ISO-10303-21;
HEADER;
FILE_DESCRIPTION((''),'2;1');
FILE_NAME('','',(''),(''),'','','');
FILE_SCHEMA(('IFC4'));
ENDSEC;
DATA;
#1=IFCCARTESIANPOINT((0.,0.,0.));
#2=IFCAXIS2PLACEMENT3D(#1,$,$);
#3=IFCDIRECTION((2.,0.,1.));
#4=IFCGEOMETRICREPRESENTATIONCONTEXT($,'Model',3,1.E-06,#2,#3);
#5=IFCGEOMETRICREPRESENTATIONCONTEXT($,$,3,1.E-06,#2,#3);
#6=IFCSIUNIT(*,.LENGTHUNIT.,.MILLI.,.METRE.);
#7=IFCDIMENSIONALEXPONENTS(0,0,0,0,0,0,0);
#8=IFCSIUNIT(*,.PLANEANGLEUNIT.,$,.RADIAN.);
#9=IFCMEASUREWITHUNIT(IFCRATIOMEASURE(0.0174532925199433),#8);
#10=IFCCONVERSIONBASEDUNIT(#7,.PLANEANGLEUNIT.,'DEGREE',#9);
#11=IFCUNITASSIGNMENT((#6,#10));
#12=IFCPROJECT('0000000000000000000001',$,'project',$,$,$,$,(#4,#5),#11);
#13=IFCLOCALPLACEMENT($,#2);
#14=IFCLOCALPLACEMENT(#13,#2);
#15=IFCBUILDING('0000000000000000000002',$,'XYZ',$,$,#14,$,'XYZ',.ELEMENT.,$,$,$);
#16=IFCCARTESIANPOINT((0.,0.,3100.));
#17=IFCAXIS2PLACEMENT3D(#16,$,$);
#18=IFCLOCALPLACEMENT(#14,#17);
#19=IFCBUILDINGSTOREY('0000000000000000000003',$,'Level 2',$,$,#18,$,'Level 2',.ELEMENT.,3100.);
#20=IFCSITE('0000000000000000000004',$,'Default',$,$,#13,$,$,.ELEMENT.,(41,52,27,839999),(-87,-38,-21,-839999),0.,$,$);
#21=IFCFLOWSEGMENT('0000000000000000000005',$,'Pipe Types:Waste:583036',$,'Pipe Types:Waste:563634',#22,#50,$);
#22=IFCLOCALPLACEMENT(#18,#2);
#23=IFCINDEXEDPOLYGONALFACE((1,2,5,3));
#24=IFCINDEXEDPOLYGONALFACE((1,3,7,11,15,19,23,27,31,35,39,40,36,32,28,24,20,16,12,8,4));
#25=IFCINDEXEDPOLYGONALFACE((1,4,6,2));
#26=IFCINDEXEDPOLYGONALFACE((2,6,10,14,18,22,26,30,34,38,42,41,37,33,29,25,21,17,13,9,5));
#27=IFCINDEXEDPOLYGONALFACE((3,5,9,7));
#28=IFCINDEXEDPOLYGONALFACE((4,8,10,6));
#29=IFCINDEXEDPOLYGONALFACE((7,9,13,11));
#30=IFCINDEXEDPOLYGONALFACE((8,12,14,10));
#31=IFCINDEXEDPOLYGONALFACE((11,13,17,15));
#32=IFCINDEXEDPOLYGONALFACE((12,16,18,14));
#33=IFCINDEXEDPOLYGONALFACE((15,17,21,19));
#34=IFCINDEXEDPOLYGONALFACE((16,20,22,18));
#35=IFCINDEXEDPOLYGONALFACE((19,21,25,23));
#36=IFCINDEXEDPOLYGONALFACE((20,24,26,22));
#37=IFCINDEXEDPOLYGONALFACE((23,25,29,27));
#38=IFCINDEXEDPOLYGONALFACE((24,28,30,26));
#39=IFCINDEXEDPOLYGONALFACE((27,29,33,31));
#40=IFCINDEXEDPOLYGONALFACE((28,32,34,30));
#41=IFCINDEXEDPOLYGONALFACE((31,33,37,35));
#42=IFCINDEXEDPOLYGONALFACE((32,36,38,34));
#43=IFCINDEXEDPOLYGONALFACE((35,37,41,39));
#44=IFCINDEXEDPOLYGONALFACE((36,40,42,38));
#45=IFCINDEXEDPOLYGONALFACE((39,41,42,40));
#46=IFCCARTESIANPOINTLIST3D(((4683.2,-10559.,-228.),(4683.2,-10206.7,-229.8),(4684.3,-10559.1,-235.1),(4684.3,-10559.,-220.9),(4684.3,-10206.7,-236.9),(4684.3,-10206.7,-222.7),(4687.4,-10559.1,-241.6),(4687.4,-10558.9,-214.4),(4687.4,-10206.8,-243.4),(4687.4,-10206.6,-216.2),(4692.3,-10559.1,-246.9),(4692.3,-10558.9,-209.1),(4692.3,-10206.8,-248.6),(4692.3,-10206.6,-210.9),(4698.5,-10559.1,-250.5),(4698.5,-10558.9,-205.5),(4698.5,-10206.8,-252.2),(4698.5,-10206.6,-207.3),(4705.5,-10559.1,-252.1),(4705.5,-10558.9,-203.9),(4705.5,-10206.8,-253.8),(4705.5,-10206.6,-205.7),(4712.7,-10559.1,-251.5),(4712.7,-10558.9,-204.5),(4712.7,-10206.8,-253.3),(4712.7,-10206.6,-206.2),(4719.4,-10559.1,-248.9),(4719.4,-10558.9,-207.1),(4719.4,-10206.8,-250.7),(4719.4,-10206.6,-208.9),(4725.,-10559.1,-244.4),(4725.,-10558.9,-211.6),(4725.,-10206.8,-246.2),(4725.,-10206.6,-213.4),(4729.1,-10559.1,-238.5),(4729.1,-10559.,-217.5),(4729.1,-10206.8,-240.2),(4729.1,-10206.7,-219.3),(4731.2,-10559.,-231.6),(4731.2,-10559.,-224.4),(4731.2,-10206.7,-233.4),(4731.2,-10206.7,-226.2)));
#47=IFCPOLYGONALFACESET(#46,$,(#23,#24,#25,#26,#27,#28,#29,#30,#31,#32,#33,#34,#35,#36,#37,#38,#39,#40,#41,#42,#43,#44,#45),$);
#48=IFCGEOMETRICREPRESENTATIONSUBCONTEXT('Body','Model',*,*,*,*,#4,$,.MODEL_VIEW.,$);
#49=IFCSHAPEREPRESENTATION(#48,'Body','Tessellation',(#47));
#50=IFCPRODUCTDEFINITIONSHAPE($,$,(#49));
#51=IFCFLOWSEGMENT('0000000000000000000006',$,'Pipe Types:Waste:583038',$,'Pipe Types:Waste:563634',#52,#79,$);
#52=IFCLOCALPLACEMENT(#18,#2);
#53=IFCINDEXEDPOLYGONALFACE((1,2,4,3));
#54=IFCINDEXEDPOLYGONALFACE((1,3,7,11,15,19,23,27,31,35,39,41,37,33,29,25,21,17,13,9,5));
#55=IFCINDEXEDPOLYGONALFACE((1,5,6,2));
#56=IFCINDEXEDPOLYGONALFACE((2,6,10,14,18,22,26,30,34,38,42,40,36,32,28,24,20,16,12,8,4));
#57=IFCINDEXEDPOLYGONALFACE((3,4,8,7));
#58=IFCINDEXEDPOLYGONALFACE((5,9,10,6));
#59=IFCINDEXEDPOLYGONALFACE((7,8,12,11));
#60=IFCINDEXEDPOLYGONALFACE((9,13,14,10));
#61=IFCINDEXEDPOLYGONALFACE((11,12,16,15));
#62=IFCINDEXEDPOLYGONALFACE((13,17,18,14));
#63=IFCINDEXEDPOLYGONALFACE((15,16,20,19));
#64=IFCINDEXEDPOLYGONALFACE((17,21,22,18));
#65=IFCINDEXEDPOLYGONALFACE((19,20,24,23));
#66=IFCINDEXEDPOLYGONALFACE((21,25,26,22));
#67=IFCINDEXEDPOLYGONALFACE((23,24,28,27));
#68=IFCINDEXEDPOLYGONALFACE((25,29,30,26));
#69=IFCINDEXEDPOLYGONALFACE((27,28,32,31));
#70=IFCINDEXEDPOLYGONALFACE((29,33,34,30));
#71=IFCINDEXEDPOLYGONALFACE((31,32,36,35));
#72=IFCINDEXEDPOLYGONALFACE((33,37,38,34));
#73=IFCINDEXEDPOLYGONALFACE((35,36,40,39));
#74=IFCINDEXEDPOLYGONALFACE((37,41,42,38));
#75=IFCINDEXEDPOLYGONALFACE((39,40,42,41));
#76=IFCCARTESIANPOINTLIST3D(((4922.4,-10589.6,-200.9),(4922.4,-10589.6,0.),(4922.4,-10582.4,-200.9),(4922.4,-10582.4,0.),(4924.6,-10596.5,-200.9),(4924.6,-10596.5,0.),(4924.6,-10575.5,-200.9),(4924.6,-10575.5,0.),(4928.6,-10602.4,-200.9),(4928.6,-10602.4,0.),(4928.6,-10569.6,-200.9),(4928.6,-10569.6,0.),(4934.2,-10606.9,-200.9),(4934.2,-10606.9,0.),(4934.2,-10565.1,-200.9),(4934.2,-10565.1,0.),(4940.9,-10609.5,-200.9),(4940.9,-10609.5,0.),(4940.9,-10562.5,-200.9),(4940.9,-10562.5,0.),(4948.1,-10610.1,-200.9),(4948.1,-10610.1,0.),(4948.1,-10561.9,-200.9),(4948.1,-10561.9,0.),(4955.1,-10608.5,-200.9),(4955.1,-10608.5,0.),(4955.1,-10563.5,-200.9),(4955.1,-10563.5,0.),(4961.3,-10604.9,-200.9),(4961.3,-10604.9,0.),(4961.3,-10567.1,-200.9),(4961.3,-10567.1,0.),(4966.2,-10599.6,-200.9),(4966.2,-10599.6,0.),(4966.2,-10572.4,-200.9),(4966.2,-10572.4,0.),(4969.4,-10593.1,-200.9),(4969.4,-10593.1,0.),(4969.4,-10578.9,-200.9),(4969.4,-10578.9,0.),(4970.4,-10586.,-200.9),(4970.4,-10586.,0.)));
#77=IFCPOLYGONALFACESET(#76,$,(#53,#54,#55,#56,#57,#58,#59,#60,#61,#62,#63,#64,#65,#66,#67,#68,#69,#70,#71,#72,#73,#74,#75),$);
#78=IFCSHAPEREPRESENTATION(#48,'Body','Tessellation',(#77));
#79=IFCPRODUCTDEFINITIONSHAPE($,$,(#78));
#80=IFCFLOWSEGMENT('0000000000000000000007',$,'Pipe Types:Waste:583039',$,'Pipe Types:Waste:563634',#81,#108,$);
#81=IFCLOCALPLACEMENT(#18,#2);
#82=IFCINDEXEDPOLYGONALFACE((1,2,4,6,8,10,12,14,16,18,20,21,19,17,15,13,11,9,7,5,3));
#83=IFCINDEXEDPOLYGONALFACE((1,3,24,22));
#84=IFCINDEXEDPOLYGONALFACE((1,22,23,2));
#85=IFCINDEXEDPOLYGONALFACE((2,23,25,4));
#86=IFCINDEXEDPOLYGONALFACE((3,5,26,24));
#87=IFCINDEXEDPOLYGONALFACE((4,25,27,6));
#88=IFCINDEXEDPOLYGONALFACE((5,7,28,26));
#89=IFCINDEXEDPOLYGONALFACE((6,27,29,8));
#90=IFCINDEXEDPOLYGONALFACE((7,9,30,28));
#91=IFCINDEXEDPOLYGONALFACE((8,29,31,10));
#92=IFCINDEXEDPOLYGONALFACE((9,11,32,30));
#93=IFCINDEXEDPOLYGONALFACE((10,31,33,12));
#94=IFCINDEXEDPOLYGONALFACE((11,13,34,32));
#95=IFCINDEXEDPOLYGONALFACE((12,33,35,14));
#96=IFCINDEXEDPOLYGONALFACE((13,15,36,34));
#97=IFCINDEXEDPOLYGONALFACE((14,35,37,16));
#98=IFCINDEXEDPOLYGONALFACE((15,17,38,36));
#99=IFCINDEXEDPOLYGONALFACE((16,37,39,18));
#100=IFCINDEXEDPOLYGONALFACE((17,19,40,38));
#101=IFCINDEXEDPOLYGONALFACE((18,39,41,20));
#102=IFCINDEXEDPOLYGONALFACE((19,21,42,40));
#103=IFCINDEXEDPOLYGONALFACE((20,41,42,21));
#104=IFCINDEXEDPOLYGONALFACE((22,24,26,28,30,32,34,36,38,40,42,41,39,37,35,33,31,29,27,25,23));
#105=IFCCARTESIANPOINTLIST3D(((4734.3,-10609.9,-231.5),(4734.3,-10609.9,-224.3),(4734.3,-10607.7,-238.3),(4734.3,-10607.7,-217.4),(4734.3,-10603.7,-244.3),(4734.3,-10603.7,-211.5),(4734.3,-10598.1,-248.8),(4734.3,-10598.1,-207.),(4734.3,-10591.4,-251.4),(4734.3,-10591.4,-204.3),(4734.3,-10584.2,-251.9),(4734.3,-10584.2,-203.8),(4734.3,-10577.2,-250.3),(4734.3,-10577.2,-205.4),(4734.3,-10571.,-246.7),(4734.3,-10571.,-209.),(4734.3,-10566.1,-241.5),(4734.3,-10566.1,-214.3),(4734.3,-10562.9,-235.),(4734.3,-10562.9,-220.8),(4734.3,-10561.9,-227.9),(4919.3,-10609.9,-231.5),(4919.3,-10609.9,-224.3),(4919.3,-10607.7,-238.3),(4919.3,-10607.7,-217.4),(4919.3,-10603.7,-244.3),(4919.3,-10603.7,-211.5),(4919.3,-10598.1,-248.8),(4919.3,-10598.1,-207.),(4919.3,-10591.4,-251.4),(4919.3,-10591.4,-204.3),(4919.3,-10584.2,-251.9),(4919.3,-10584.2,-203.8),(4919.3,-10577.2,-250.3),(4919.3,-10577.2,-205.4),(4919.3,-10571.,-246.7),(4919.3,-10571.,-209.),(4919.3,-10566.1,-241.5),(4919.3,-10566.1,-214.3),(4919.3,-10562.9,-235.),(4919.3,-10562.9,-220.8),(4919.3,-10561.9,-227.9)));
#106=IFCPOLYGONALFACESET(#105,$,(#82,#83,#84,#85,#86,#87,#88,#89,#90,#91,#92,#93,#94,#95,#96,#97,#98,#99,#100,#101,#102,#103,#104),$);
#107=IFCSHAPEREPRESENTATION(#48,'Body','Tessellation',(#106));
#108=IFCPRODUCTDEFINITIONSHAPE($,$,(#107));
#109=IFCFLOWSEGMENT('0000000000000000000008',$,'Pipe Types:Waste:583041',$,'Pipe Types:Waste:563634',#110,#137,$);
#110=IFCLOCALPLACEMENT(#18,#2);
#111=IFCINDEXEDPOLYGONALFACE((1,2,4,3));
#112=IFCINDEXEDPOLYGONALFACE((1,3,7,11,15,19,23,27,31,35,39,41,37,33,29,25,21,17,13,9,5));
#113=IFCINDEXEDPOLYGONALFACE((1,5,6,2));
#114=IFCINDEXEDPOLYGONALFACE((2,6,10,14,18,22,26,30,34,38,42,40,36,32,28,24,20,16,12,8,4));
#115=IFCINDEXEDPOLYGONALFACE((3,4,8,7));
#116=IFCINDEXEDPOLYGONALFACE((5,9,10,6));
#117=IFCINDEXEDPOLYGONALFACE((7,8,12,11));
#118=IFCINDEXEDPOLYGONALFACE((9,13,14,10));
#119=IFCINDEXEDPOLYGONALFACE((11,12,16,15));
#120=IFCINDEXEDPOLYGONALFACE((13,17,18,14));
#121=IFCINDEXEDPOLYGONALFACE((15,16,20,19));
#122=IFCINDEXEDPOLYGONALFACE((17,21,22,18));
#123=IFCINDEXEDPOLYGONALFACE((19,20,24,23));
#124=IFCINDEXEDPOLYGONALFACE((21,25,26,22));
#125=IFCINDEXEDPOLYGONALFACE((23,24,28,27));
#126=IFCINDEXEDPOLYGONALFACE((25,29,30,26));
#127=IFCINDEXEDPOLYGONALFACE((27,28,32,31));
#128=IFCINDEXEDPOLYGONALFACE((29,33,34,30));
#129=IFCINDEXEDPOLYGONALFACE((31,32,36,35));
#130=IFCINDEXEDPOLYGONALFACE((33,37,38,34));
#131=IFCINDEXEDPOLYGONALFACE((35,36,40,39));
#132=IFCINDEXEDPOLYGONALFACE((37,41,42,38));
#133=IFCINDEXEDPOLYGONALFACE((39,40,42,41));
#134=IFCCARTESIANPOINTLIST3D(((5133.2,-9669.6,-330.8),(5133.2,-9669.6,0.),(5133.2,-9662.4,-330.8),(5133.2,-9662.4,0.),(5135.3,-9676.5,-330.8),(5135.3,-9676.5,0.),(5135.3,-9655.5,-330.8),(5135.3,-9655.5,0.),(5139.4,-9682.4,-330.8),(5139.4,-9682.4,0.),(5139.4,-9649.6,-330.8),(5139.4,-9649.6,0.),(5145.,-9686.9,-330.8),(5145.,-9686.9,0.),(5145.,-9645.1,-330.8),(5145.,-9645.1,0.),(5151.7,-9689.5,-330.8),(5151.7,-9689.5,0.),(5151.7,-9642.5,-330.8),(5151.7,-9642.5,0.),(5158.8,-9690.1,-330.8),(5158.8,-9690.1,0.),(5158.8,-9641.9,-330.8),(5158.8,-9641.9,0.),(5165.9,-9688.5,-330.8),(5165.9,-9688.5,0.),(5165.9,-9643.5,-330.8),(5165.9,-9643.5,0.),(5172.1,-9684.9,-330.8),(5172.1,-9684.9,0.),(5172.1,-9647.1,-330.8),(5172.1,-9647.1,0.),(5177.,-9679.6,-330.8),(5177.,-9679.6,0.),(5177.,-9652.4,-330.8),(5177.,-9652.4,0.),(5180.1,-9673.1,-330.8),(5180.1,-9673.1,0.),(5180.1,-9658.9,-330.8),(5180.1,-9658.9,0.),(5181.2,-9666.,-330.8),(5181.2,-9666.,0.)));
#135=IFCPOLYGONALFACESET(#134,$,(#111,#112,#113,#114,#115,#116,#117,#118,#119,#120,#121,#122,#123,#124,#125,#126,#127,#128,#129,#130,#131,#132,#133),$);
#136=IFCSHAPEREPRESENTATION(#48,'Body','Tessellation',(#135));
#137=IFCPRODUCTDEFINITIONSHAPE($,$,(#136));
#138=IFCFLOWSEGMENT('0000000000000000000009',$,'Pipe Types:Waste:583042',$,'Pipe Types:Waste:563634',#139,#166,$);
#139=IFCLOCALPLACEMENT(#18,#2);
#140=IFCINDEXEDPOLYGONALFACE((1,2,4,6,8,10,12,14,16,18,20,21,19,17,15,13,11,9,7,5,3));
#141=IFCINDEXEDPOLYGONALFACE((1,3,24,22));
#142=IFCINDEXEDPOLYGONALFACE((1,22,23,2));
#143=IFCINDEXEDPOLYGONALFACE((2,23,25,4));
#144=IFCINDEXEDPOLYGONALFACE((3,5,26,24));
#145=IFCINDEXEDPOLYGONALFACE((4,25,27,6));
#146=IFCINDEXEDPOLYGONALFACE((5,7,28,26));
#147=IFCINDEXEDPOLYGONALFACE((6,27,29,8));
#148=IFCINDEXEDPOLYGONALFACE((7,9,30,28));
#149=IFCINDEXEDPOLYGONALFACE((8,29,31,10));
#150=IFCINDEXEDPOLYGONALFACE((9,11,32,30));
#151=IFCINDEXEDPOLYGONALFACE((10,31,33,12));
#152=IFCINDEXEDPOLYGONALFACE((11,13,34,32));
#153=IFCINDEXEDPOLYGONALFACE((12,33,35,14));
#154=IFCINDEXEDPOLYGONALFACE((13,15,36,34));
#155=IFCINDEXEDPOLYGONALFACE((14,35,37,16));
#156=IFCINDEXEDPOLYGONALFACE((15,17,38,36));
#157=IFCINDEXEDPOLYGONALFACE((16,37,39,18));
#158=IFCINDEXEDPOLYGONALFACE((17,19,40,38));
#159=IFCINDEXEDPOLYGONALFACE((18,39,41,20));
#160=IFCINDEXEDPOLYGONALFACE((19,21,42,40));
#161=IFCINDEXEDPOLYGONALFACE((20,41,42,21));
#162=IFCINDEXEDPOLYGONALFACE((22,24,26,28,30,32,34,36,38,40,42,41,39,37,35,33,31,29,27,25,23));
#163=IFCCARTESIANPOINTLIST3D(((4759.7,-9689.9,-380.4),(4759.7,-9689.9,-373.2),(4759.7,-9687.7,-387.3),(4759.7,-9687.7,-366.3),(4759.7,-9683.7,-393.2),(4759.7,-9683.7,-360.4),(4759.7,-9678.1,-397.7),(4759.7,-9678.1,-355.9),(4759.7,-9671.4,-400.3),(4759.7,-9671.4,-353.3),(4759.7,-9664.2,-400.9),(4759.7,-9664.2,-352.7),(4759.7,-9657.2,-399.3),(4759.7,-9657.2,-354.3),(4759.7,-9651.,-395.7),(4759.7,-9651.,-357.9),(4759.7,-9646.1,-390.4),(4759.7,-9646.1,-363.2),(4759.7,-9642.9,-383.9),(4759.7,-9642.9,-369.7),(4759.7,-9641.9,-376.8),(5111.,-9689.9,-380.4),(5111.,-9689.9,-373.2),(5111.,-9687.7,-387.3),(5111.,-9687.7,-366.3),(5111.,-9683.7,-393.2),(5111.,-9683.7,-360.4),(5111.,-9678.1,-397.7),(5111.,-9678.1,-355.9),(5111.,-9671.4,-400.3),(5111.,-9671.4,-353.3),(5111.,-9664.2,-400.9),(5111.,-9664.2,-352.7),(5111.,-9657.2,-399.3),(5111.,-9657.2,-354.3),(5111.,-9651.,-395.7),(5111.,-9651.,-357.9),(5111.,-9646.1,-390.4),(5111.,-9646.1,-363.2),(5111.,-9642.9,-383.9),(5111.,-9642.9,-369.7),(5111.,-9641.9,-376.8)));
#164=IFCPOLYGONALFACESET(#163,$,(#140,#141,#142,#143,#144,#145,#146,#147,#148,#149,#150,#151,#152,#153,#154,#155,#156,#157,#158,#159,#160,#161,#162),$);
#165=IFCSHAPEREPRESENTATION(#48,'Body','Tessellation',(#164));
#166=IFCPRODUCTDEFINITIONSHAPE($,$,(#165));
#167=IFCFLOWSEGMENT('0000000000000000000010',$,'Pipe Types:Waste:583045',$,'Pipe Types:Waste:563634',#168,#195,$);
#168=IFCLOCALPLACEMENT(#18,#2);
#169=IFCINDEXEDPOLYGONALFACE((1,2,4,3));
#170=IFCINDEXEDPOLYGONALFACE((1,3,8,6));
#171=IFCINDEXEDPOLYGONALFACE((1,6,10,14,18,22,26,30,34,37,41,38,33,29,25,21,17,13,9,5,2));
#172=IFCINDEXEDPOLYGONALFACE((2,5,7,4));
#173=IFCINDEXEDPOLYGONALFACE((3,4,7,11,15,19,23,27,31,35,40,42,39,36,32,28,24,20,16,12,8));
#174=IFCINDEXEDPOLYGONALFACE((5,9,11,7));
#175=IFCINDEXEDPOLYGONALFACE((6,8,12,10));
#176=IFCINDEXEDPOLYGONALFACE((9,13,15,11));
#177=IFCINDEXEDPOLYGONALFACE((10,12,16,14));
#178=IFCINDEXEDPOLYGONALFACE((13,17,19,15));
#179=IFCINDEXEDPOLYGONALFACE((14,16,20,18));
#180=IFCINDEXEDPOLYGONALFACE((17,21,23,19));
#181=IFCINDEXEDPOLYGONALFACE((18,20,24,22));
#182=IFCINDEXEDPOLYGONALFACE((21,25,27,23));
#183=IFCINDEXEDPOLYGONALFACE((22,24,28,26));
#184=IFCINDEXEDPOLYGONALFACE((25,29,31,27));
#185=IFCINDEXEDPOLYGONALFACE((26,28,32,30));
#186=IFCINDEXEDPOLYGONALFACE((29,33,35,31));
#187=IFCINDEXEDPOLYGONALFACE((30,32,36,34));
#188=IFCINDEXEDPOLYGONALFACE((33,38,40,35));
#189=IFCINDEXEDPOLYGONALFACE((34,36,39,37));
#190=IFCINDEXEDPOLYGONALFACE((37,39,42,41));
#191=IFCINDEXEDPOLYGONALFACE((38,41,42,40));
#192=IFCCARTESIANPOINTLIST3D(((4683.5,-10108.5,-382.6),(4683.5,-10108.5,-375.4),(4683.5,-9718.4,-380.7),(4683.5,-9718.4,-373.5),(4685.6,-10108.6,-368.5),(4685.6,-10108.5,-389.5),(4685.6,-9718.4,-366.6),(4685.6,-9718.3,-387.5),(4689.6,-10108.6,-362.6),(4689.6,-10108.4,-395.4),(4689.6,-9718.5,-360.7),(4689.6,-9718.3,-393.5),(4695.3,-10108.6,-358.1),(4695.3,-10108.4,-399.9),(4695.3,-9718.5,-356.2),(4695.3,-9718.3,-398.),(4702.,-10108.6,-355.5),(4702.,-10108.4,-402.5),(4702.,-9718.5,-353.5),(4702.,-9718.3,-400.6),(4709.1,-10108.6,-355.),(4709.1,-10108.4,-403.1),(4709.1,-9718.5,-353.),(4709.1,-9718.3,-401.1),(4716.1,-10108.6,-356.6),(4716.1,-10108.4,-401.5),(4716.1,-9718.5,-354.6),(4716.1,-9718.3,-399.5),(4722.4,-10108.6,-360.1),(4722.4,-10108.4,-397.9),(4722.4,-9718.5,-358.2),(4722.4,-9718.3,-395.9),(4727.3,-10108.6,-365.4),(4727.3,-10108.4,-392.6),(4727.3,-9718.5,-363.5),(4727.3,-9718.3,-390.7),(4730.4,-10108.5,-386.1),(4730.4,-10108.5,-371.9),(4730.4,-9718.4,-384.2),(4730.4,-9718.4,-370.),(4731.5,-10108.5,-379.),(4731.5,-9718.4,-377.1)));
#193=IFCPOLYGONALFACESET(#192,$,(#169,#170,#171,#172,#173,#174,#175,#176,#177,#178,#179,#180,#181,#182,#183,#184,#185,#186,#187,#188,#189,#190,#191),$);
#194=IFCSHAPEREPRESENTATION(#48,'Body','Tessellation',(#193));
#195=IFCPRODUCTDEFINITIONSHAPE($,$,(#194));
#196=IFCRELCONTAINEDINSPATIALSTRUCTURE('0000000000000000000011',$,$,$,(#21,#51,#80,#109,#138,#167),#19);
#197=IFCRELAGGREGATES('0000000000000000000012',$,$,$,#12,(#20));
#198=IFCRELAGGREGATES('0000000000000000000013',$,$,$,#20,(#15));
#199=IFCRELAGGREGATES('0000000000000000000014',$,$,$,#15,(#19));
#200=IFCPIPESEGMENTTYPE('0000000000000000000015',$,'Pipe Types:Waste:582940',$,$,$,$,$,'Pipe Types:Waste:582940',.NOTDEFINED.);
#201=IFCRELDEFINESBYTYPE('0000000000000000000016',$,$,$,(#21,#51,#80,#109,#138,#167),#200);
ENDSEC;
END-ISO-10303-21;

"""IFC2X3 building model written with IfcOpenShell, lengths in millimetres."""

from ifc_helpers import new_model, entity, si_unit, converted_unit, direction, frame, frame_2d, origin, origin_2d_with_axis, place, context, subcontext, project, spatial, circle, extrude, type_object, element, save


model = new_model("IFC2X3")

# Units and contexts
model_context = context("Model", 3, precision=1e-06, world=origin(), true_north=direction((2.0, 0.0, 1.0)))
context_of_model = context(None, 3, precision=1e-06, world=origin(), true_north=direction((2.0, 0.0, 1.0)))
body_context = subcontext(model_context, "Body", "Model", "MODEL_VIEW")
ifc_project = project(units=[si_unit("LENGTHUNIT", "METRE", prefix="MILLI"), converted_unit("PLANEANGLEUNIT", "DEGREE", entity("IfcRatioMeasure", 0.0174532925199433), si_unit("PLANEANGLEUNIT", "RADIAN"), dimensions=[0, 0, 0, 0, 0, 0, 0])], contexts=[model_context, context_of_model])

# Site, building, storey
site_placement = place(None, origin())
site = spatial("IfcSite", under=ifc_project, at=site_placement, Name="Default", CompositionType="ELEMENT", RefLatitude=(41, 52, 27, 839999), RefLongitude=(-87, -38, -21, -839999), RefElevation=0.0)
building_placement = place(site_placement, origin())
building = spatial("IfcBuilding", under=site, at=building_placement, Name="XYZ", LongName="XYZ", CompositionType="ELEMENT")
storey_placement = place(building_placement, frame((0.0, 0.0, 3100.0)))
storey = spatial("IfcBuildingStorey", under=building, at=storey_placement, Name="Level 2", LongName="Level 2", CompositionType="ELEMENT", Elevation=3100.0)

# Flow segments
pipe_segment_type_1 = type_object("IfcPipeSegmentType", Name="Pipe Types:Waste:582940", ElementType="Pipe Types:Waste:582940", PredefinedType="NOTDEFINED")
flow_segment_1_placement = place(storey_placement, origin())
element("IfcFlowSegment", 1, at=flow_segment_1_placement, inside=storey, type_object=pipe_segment_type_1, Name="Pipe Types:Waste:583036", ObjectType="Pipe Types:Waste:563634", context=body_context, shape_type="SweptSolid", body=[
    extrude(circle(Radius=24.1, at=origin_2d_with_axis()), frame((4707.3, -10206.7, -229.8), z_axis=(0.0, -0.999988, 0.005), x_axis=(-1.0, 0.0, 0.0)), (0.0, 0.0, 1.0), 352.3),
])
flow_segment_2_placement = place(storey_placement, origin())
element("IfcFlowSegment", 2, at=flow_segment_2_placement, inside=storey, type_object=pipe_segment_type_1, Name="Pipe Types:Waste:583038", ObjectType="Pipe Types:Waste:563634", context=body_context, shape_type="SweptSolid", body=[
    extrude(circle(Radius=24.1, at=origin_2d_with_axis()), frame((4946.3, -10586.0, -200.9)), (0.0, 0.0, 1.0), 200.9),
])
flow_segment_3_placement = place(storey_placement, origin())
element("IfcFlowSegment", 3, at=flow_segment_3_placement, inside=storey, type_object=pipe_segment_type_1, Name="Pipe Types:Waste:583039", ObjectType="Pipe Types:Waste:563634", context=body_context, shape_type="SweptSolid", body=[
    extrude(circle(Radius=24.1, at=frame_2d((0.0, 0.0), x_axis=(1.0, 0.0))), frame((4734.3, -10586.0, -227.9), z_axis=(1.0, 0.0, 0.0), x_axis=(0.0, 1.0, 0.0)), (0.0, 0.0, 1.0), 185.0),
])
flow_segment_4_placement = place(storey_placement, origin())
element("IfcFlowSegment", 4, at=flow_segment_4_placement, inside=storey, type_object=pipe_segment_type_1, Name="Pipe Types:Waste:583041", ObjectType="Pipe Types:Waste:563634", context=body_context, shape_type="SweptSolid", body=[
    extrude(circle(Radius=24.1, at=origin_2d_with_axis()), frame((5157.0, -9666.0, -330.8)), (0.0, 0.0, 1.0), 330.8),
])
flow_segment_5_placement = place(storey_placement, origin())
element("IfcFlowSegment", 5, at=flow_segment_5_placement, inside=storey, type_object=pipe_segment_type_1, Name="Pipe Types:Waste:583042", ObjectType="Pipe Types:Waste:563634", context=body_context, shape_type="SweptSolid", body=[
    extrude(circle(Radius=24.1, at=origin_2d_with_axis()), frame((4759.7, -9666.0, -376.8), z_axis=(1.0, 0.0, 0.0), x_axis=(0.0, 1.0, 0.0)), (0.0, 0.0, 1.0), 351.3),
])
flow_segment_6_placement = place(storey_placement, origin())
element("IfcFlowSegment", 6, at=flow_segment_6_placement, inside=storey, type_object=pipe_segment_type_1, Name="Pipe Types:Waste:583045", ObjectType="Pipe Types:Waste:563634", context=body_context, shape_type="SweptSolid", body=[
    extrude(circle(Radius=24.1, at=frame_2d((0.0, 0.0), x_axis=(1.0, 0.0))), frame((4707.3, -10108.5, -379.0), z_axis=(0.0, 0.999988, 0.005), x_axis=(1.0, 0.0, 0.0)), (0.0, 0.0, 1.0), 390.1),
])

save(model, "model.ifc")
